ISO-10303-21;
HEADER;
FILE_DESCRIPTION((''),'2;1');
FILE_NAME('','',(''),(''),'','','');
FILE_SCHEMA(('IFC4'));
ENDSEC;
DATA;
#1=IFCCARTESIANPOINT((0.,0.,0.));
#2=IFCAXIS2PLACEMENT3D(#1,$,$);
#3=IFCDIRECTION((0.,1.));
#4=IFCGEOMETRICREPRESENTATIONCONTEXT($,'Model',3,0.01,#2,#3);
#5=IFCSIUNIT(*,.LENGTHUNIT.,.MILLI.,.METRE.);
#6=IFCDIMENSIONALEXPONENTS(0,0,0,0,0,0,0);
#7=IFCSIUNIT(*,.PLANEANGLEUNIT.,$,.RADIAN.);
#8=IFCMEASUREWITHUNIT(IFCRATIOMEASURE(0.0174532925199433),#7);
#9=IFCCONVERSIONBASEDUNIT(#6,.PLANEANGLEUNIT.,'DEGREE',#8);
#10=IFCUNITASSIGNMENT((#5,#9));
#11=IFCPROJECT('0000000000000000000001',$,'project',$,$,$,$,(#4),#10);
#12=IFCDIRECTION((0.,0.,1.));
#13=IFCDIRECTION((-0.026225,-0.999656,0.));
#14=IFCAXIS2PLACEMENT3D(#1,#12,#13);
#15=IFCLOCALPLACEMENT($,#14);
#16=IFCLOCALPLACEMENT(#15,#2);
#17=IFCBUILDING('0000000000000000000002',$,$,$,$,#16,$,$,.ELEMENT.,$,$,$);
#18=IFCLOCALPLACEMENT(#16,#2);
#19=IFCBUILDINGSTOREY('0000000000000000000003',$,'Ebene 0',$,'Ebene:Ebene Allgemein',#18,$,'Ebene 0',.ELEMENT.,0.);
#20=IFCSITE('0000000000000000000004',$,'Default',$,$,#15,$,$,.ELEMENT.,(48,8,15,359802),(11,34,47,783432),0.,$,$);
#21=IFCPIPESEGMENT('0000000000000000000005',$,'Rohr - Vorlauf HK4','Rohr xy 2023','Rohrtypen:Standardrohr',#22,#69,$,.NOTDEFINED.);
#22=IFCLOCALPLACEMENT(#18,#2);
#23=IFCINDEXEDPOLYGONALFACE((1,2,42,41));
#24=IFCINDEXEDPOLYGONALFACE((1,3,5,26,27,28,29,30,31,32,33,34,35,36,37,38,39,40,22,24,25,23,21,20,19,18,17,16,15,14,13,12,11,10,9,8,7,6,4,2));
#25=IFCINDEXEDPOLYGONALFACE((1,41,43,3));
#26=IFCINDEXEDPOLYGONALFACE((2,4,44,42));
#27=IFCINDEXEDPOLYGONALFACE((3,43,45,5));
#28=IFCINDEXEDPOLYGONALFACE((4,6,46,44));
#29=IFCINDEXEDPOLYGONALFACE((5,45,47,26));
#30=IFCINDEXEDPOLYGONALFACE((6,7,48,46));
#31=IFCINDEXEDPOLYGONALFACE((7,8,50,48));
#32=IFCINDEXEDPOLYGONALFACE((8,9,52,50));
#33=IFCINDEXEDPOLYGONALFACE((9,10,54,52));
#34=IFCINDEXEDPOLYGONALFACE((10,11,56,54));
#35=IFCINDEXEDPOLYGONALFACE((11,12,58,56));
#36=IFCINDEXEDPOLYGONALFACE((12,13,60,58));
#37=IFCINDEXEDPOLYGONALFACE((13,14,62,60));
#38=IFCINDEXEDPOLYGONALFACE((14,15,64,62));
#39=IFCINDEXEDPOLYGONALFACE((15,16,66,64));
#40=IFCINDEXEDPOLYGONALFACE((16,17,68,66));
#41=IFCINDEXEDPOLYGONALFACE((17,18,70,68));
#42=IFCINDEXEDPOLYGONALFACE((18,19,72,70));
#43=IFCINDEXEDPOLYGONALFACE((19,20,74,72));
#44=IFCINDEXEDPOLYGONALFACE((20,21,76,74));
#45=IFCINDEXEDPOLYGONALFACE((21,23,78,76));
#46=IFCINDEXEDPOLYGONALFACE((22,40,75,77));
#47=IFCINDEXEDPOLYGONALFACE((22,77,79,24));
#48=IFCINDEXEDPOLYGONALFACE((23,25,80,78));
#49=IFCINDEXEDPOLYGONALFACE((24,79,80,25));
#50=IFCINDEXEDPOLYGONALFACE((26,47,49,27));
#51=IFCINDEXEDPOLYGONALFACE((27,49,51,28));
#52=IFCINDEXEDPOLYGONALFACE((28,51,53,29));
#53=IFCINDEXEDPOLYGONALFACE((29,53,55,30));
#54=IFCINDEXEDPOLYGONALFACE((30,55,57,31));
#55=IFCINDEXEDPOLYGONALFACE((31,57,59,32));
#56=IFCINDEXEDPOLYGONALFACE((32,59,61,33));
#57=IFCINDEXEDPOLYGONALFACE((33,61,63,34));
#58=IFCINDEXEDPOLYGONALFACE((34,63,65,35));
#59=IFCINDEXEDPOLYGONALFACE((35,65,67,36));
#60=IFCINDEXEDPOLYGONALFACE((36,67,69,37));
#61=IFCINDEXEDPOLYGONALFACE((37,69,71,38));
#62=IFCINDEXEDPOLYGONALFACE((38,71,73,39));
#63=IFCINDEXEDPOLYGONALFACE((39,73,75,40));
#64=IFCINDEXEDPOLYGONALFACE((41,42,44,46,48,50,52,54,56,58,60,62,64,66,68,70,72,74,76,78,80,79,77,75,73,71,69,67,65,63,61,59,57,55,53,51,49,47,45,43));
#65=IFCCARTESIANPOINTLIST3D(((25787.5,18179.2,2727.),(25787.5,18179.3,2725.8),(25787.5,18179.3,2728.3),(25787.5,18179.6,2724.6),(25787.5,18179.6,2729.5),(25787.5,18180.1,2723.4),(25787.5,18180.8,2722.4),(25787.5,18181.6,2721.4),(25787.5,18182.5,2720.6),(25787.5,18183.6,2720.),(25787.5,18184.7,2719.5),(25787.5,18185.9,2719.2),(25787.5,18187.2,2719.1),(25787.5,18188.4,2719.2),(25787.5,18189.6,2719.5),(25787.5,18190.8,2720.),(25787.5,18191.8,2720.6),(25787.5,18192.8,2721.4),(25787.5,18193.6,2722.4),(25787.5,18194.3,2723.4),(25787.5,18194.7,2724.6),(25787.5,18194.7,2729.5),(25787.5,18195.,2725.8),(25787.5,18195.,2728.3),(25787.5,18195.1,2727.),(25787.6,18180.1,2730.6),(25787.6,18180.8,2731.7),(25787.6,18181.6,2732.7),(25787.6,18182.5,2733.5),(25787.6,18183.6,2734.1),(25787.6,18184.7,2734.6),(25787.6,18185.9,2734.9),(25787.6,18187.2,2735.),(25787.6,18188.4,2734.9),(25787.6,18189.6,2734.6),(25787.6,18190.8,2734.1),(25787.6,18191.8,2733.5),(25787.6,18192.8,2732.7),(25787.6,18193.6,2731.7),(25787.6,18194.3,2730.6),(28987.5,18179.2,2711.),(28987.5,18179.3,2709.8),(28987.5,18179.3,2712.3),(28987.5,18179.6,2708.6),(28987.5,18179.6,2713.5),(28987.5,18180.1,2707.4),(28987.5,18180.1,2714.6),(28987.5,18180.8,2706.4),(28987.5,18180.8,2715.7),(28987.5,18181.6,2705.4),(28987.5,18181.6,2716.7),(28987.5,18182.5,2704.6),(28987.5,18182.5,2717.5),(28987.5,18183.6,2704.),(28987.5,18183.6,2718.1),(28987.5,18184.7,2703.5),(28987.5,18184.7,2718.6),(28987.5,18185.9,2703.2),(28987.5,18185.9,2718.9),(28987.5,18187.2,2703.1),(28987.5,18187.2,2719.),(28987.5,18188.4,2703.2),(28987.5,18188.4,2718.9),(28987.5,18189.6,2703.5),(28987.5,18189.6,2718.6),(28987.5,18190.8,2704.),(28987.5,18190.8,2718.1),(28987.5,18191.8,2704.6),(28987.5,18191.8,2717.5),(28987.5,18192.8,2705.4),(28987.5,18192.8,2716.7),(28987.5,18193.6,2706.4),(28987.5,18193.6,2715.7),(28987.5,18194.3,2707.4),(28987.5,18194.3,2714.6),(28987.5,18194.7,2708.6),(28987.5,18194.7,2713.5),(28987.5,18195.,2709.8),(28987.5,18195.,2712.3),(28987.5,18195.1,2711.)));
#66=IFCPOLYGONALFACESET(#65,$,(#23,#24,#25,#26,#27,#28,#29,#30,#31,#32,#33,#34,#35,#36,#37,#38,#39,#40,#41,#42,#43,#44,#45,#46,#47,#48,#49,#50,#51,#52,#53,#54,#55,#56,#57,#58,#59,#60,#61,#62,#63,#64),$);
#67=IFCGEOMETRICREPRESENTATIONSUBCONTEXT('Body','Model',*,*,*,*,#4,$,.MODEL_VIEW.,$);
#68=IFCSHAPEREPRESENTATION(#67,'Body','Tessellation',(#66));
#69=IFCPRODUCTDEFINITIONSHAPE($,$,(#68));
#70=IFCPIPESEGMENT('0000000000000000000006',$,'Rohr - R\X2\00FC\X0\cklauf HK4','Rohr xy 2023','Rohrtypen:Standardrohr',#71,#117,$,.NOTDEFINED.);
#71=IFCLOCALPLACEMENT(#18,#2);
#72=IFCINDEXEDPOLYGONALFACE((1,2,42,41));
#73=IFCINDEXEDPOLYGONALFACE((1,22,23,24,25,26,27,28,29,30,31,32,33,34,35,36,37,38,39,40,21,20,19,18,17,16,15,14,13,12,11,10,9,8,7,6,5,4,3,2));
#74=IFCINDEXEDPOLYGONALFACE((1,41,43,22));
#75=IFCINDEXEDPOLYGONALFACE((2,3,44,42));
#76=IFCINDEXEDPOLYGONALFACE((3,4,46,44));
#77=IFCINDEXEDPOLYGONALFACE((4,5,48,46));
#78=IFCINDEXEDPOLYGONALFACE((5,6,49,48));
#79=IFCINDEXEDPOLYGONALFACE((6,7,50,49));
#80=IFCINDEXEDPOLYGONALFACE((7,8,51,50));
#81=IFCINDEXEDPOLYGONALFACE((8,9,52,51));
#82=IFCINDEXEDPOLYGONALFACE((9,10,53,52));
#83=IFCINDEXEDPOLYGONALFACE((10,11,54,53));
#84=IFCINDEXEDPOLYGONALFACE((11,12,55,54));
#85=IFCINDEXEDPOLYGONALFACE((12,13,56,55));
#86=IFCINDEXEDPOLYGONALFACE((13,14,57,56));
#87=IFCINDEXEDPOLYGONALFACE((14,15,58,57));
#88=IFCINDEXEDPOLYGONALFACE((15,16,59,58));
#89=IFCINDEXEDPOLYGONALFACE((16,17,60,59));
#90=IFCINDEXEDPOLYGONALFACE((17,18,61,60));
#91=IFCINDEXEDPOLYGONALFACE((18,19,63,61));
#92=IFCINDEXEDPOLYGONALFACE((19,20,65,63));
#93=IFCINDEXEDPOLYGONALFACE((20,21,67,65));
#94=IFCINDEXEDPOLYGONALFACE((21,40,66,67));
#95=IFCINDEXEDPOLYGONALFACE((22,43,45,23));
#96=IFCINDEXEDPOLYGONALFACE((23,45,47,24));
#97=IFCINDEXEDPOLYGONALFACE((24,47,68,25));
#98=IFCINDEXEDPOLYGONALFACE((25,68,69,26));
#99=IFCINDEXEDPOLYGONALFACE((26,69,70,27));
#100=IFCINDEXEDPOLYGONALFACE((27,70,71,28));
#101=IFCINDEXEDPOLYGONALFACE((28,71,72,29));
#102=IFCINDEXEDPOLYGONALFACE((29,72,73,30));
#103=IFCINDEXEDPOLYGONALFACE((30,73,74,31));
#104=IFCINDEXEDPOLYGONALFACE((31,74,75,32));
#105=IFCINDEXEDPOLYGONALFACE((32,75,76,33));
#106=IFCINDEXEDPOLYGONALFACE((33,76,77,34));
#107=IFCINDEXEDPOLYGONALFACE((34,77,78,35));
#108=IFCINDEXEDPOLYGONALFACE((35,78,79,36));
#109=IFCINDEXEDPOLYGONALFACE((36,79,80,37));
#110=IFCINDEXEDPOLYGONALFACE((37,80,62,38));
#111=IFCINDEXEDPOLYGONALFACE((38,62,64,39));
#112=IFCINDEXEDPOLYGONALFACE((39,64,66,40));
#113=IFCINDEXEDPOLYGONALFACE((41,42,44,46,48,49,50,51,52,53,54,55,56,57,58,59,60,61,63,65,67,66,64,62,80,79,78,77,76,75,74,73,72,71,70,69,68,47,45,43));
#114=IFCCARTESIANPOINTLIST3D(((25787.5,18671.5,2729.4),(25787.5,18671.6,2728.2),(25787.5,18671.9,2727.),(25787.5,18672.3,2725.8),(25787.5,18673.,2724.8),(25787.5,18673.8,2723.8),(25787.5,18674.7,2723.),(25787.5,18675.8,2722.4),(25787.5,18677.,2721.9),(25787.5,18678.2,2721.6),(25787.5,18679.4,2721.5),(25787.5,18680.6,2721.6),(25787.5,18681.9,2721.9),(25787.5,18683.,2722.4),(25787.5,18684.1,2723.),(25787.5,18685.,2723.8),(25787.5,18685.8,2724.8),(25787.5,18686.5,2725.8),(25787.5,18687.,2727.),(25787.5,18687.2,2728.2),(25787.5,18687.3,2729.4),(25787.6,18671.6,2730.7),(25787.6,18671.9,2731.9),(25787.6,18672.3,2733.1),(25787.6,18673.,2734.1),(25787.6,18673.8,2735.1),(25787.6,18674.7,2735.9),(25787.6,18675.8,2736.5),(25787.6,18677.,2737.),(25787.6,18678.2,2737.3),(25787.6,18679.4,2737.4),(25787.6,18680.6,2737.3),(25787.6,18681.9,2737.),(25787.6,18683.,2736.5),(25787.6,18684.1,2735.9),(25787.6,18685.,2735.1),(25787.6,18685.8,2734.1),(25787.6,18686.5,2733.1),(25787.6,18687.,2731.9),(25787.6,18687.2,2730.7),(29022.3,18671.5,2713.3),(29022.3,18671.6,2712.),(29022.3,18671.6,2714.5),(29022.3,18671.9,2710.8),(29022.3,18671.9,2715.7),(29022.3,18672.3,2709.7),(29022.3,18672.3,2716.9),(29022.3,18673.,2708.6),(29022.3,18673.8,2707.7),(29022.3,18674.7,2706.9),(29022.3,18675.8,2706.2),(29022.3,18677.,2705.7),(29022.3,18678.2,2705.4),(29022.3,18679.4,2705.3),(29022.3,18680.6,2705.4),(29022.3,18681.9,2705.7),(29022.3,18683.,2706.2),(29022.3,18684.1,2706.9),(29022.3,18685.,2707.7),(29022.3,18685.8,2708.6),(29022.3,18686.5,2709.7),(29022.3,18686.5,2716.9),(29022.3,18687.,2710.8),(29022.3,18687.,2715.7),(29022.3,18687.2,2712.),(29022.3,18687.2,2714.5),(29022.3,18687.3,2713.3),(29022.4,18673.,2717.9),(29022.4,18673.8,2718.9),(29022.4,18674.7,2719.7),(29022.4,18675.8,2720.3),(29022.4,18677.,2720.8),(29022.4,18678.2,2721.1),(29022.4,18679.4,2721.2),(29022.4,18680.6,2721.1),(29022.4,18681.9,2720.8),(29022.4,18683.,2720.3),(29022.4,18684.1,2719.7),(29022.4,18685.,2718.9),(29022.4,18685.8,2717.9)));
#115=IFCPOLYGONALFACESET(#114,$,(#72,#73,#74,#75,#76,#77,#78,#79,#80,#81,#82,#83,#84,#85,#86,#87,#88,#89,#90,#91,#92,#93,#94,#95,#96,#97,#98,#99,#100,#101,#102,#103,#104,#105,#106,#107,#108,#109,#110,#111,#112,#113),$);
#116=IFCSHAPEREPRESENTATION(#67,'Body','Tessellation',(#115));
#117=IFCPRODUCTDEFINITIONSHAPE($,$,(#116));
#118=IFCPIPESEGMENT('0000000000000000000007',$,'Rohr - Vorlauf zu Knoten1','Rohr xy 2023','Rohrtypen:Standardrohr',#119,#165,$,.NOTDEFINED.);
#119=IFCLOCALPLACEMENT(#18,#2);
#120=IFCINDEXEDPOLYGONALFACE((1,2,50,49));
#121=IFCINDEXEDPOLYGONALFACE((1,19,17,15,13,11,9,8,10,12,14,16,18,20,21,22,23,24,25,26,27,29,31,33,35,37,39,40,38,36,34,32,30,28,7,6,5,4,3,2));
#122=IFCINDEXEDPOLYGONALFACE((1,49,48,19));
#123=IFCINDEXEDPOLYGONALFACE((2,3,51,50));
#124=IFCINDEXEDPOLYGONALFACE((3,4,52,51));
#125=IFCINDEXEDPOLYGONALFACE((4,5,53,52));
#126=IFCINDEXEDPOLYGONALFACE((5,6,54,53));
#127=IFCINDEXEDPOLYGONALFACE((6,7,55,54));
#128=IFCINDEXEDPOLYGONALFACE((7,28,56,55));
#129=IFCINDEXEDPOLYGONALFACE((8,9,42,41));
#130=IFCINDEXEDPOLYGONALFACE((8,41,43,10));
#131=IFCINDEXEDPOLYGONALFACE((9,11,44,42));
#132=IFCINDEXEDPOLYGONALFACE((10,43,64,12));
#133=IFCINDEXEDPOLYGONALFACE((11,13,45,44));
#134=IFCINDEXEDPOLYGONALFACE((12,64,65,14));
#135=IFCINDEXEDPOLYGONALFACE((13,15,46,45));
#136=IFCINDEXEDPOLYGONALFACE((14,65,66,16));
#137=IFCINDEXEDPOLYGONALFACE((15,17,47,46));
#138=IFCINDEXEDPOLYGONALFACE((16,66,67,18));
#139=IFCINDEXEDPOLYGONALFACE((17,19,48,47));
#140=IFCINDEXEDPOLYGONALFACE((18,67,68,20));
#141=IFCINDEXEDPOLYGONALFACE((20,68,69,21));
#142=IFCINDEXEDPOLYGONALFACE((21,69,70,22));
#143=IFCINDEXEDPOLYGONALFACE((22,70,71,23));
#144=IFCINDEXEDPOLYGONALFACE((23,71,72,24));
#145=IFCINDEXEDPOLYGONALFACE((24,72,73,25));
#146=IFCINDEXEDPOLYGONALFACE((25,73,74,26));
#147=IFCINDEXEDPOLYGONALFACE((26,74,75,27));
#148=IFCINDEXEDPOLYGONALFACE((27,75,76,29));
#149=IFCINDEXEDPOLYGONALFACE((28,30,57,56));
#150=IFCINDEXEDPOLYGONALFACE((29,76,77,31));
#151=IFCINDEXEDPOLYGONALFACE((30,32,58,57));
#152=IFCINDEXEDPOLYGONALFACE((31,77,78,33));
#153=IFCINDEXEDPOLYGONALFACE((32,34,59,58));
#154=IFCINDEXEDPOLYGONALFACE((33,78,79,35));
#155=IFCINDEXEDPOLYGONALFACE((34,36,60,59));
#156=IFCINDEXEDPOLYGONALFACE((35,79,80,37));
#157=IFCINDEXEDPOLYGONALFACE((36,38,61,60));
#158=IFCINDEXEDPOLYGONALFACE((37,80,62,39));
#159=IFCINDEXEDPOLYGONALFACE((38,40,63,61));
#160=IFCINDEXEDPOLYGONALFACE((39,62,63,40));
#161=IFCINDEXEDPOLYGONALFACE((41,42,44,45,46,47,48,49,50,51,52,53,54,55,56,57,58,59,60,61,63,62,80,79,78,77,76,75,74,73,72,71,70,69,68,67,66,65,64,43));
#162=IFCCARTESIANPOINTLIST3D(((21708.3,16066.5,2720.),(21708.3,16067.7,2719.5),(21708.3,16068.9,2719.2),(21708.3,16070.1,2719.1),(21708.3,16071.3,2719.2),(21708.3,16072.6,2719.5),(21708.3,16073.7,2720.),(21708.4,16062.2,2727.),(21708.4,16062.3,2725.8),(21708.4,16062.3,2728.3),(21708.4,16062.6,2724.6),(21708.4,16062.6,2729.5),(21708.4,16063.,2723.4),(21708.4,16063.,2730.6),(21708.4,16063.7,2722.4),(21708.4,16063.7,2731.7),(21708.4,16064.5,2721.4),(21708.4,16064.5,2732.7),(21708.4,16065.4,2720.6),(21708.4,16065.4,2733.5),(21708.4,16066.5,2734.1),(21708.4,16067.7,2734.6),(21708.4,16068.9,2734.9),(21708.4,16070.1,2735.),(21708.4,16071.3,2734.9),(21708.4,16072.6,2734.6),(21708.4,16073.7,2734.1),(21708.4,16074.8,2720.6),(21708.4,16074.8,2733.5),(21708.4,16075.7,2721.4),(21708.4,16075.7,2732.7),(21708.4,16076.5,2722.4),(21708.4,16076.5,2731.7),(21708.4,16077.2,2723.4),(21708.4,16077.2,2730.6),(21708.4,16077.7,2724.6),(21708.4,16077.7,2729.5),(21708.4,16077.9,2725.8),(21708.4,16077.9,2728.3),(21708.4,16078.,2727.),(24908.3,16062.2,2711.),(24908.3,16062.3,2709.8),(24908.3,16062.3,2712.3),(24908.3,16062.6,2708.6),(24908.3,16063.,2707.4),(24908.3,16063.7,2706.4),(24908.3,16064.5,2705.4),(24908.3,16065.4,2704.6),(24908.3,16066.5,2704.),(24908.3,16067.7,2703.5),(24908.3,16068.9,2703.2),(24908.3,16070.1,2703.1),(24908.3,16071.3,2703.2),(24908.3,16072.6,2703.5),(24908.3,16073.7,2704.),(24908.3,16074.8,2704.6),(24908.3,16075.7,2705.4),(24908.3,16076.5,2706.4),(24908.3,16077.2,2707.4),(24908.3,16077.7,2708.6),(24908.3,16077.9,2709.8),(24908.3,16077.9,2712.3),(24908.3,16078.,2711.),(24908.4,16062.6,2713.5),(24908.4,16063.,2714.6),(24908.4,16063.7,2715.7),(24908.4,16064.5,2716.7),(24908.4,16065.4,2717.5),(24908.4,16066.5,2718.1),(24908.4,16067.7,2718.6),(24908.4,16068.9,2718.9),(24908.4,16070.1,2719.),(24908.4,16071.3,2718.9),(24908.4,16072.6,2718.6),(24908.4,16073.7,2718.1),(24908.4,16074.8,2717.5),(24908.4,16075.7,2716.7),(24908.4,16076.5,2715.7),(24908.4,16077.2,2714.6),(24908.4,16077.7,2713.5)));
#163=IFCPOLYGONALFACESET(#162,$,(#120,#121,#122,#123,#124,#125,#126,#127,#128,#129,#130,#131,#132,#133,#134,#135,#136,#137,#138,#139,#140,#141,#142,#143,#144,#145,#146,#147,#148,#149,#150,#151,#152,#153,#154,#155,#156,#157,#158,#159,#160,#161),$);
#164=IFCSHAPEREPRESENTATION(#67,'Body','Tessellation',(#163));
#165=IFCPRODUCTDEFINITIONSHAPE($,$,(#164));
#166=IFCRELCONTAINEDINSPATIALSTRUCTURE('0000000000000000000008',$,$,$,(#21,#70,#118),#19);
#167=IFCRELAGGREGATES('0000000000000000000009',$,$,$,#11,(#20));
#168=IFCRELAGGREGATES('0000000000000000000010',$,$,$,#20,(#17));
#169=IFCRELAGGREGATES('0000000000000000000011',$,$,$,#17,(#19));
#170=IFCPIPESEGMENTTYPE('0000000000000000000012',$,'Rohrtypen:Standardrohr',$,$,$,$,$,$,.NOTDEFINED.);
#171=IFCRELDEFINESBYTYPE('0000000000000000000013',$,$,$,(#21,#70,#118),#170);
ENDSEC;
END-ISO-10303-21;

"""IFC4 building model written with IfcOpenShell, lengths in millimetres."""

from ifc_helpers import new_model, entity, si_unit, converted_unit, direction, frame, origin, place, context, subcontext, project, spatial, indexed_curve, outline, extrude, type_object, element, save


model = new_model("IFC4")

# Units and contexts
model_context = context("Model", 3, precision=0.01, world=origin(), true_north=direction((0.0, 1.0)))
body_context = subcontext(model_context, "Body", "Model", "MODEL_VIEW")
ifc_project = project(units=[si_unit("LENGTHUNIT", "METRE", prefix="MILLI"), converted_unit("PLANEANGLEUNIT", "DEGREE", entity("IfcRatioMeasure", 0.0174532925199433), si_unit("PLANEANGLEUNIT", "RADIAN"), dimensions=[0, 0, 0, 0, 0, 0, 0])], contexts=[model_context])

# Site, building, storey
site_placement = place(None, frame((0.0, 0.0, 0.0), z_axis=(0.0, 0.0, 1.0), x_axis=(-0.026225, -0.999656, 0.0)))
site = spatial("IfcSite", under=ifc_project, at=site_placement, Name="Default", CompositionType="ELEMENT", RefLatitude=(48, 8, 15, 359802), RefLongitude=(11, 34, 47, 783432), RefElevation=0.0)
building_placement = place(site_placement, origin())
building = spatial("IfcBuilding", under=site, at=building_placement, CompositionType="ELEMENT")
storey_placement = place(building_placement, origin())
storey = spatial("IfcBuildingStorey", under=building, at=storey_placement, Name="Ebene 0", ObjectType="Ebene:Ebene Allgemein", LongName="Ebene 0", CompositionType="ELEMENT", Elevation=0.0)

# Pipe segments
pipe_segment_type = type_object("IfcPipeSegmentType", Name="Rohrtypen:Standardrohr", PredefinedType="NOTDEFINED")
pipe_segment_1_placement = place(storey_placement, origin())
element("IfcPipeSegment", 1, at=pipe_segment_1_placement, inside=storey, type_object=pipe_segment_type, Name="Rohr - Vorlauf HK4", Description="Rohr xy 2023", ObjectType="Rohrtypen:Standardrohr", PredefinedType="NOTDEFINED", context=body_context, shape_type="SweptSolid", body=[
    extrude(outline(indexed_curve([(7.9, 0.0), (7.8, 1.2), (7.6, 2.5), (7.1, 3.6), (6.4, 4.7), (5.6, 5.6), (4.7, 6.4), (3.6, 7.1), (2.5, 7.6), (1.2, 7.8), (0.0, 7.9), (-1.2, 7.8), (-2.5, 7.6), (-3.6, 7.1), (-4.7, 6.4), (-5.6, 5.6), (-6.4, 4.7), (-7.1, 3.6), (-7.6, 2.5), (-7.8, 1.2), (-7.9, 0.0), (-7.8, -1.2), (-7.6, -2.5), (-7.1, -3.6), (-6.4, -4.7), (-5.6, -5.6), (-4.7, -6.4), (-3.6, -7.1), (-2.5, -7.6), (-1.2, -7.8), (0.0, -7.9), (1.2, -7.8), (2.5, -7.6), (3.6, -7.1), (4.7, -6.4), (5.6, -5.6), (6.4, -4.7), (7.1, -3.6), (7.6, -2.5), (7.8, -1.2), (7.9, 0.0)], self_intersect=False)), frame((28987.5, 18187.2, 2711.0), z_axis=(-0.999988, 0.0, 0.005), x_axis=(0.0, 1.0, 0.0)), (0.0, 0.0, 1.0), 3200.0),
])
pipe_segment_2_placement = place(storey_placement, origin())
element("IfcPipeSegment", 2, at=pipe_segment_2_placement, inside=storey, type_object=pipe_segment_type, Name="Rohr - Rücklauf HK4", Description="Rohr xy 2023", ObjectType="Rohrtypen:Standardrohr", PredefinedType="NOTDEFINED", context=body_context, shape_type="SweptSolid", body=[
    extrude(outline(indexed_curve([(7.9, 0.0), (7.8, 1.2), (7.6, 2.5), (7.1, 3.6), (6.4, 4.7), (5.6, 5.6), (4.7, 6.4), (3.6, 7.1), (2.5, 7.6), (1.2, 7.8), (0.0, 7.9), (-1.2, 7.8), (-2.5, 7.6), (-3.6, 7.1), (-4.7, 6.4), (-5.6, 5.6), (-6.4, 4.7), (-7.1, 3.6), (-7.6, 2.5), (-7.8, 1.2), (-7.9, 0.0), (-7.8, -1.2), (-7.6, -2.5), (-7.1, -3.6), (-6.4, -4.7), (-5.6, -5.6), (-4.7, -6.4), (-3.6, -7.1), (-2.5, -7.6), (-1.2, -7.8), (0.0, -7.9), (1.2, -7.8), (2.5, -7.6), (3.6, -7.1), (4.7, -6.4), (5.6, -5.6), (6.4, -4.7), (7.1, -3.6), (7.6, -2.5), (7.8, -1.2), (7.9, 0.0)], self_intersect=False)), frame((29022.3, 18679.4, 2713.3), z_axis=(-0.999988, 0.0, 0.005), x_axis=(0.0, 1.0, 0.0)), (0.0, 0.0, 1.0), 3234.8),
])
pipe_segment_3_placement = place(storey_placement, origin())
element("IfcPipeSegment", 3, at=pipe_segment_3_placement, inside=storey, type_object=pipe_segment_type, Name="Rohr - Vorlauf zu Knoten1", Description="Rohr xy 2023", ObjectType="Rohrtypen:Standardrohr", PredefinedType="NOTDEFINED", context=body_context, shape_type="SweptSolid", body=[
    extrude(outline(indexed_curve([(7.9, 0.0), (7.8, 1.2), (7.6, 2.5), (7.1, 3.6), (6.4, 4.7), (5.6, 5.6), (4.7, 6.4), (3.6, 7.1), (2.5, 7.6), (1.2, 7.8), (0.0, 7.9), (-1.2, 7.8), (-2.5, 7.6), (-3.6, 7.1), (-4.7, 6.4), (-5.6, 5.6), (-6.4, 4.7), (-7.1, 3.6), (-7.6, 2.5), (-7.8, 1.2), (-7.9, 0.0), (-7.8, -1.2), (-7.6, -2.5), (-7.1, -3.6), (-6.4, -4.7), (-5.6, -5.6), (-4.7, -6.4), (-3.6, -7.1), (-2.5, -7.6), (-1.2, -7.8), (0.0, -7.9), (1.2, -7.8), (2.5, -7.6), (3.6, -7.1), (4.7, -6.4), (5.6, -5.6), (6.4, -4.7), (7.1, -3.6), (7.6, -2.5), (7.8, -1.2), (7.9, 0.0)], self_intersect=False)), frame((24908.3, 16070.1, 2711.0), z_axis=(-0.999988, 0.0, 0.005), x_axis=(0.0, 1.0, 0.0)), (0.0, 0.0, 1.0), 3200.0),
])

save(model, "model.ifc")
